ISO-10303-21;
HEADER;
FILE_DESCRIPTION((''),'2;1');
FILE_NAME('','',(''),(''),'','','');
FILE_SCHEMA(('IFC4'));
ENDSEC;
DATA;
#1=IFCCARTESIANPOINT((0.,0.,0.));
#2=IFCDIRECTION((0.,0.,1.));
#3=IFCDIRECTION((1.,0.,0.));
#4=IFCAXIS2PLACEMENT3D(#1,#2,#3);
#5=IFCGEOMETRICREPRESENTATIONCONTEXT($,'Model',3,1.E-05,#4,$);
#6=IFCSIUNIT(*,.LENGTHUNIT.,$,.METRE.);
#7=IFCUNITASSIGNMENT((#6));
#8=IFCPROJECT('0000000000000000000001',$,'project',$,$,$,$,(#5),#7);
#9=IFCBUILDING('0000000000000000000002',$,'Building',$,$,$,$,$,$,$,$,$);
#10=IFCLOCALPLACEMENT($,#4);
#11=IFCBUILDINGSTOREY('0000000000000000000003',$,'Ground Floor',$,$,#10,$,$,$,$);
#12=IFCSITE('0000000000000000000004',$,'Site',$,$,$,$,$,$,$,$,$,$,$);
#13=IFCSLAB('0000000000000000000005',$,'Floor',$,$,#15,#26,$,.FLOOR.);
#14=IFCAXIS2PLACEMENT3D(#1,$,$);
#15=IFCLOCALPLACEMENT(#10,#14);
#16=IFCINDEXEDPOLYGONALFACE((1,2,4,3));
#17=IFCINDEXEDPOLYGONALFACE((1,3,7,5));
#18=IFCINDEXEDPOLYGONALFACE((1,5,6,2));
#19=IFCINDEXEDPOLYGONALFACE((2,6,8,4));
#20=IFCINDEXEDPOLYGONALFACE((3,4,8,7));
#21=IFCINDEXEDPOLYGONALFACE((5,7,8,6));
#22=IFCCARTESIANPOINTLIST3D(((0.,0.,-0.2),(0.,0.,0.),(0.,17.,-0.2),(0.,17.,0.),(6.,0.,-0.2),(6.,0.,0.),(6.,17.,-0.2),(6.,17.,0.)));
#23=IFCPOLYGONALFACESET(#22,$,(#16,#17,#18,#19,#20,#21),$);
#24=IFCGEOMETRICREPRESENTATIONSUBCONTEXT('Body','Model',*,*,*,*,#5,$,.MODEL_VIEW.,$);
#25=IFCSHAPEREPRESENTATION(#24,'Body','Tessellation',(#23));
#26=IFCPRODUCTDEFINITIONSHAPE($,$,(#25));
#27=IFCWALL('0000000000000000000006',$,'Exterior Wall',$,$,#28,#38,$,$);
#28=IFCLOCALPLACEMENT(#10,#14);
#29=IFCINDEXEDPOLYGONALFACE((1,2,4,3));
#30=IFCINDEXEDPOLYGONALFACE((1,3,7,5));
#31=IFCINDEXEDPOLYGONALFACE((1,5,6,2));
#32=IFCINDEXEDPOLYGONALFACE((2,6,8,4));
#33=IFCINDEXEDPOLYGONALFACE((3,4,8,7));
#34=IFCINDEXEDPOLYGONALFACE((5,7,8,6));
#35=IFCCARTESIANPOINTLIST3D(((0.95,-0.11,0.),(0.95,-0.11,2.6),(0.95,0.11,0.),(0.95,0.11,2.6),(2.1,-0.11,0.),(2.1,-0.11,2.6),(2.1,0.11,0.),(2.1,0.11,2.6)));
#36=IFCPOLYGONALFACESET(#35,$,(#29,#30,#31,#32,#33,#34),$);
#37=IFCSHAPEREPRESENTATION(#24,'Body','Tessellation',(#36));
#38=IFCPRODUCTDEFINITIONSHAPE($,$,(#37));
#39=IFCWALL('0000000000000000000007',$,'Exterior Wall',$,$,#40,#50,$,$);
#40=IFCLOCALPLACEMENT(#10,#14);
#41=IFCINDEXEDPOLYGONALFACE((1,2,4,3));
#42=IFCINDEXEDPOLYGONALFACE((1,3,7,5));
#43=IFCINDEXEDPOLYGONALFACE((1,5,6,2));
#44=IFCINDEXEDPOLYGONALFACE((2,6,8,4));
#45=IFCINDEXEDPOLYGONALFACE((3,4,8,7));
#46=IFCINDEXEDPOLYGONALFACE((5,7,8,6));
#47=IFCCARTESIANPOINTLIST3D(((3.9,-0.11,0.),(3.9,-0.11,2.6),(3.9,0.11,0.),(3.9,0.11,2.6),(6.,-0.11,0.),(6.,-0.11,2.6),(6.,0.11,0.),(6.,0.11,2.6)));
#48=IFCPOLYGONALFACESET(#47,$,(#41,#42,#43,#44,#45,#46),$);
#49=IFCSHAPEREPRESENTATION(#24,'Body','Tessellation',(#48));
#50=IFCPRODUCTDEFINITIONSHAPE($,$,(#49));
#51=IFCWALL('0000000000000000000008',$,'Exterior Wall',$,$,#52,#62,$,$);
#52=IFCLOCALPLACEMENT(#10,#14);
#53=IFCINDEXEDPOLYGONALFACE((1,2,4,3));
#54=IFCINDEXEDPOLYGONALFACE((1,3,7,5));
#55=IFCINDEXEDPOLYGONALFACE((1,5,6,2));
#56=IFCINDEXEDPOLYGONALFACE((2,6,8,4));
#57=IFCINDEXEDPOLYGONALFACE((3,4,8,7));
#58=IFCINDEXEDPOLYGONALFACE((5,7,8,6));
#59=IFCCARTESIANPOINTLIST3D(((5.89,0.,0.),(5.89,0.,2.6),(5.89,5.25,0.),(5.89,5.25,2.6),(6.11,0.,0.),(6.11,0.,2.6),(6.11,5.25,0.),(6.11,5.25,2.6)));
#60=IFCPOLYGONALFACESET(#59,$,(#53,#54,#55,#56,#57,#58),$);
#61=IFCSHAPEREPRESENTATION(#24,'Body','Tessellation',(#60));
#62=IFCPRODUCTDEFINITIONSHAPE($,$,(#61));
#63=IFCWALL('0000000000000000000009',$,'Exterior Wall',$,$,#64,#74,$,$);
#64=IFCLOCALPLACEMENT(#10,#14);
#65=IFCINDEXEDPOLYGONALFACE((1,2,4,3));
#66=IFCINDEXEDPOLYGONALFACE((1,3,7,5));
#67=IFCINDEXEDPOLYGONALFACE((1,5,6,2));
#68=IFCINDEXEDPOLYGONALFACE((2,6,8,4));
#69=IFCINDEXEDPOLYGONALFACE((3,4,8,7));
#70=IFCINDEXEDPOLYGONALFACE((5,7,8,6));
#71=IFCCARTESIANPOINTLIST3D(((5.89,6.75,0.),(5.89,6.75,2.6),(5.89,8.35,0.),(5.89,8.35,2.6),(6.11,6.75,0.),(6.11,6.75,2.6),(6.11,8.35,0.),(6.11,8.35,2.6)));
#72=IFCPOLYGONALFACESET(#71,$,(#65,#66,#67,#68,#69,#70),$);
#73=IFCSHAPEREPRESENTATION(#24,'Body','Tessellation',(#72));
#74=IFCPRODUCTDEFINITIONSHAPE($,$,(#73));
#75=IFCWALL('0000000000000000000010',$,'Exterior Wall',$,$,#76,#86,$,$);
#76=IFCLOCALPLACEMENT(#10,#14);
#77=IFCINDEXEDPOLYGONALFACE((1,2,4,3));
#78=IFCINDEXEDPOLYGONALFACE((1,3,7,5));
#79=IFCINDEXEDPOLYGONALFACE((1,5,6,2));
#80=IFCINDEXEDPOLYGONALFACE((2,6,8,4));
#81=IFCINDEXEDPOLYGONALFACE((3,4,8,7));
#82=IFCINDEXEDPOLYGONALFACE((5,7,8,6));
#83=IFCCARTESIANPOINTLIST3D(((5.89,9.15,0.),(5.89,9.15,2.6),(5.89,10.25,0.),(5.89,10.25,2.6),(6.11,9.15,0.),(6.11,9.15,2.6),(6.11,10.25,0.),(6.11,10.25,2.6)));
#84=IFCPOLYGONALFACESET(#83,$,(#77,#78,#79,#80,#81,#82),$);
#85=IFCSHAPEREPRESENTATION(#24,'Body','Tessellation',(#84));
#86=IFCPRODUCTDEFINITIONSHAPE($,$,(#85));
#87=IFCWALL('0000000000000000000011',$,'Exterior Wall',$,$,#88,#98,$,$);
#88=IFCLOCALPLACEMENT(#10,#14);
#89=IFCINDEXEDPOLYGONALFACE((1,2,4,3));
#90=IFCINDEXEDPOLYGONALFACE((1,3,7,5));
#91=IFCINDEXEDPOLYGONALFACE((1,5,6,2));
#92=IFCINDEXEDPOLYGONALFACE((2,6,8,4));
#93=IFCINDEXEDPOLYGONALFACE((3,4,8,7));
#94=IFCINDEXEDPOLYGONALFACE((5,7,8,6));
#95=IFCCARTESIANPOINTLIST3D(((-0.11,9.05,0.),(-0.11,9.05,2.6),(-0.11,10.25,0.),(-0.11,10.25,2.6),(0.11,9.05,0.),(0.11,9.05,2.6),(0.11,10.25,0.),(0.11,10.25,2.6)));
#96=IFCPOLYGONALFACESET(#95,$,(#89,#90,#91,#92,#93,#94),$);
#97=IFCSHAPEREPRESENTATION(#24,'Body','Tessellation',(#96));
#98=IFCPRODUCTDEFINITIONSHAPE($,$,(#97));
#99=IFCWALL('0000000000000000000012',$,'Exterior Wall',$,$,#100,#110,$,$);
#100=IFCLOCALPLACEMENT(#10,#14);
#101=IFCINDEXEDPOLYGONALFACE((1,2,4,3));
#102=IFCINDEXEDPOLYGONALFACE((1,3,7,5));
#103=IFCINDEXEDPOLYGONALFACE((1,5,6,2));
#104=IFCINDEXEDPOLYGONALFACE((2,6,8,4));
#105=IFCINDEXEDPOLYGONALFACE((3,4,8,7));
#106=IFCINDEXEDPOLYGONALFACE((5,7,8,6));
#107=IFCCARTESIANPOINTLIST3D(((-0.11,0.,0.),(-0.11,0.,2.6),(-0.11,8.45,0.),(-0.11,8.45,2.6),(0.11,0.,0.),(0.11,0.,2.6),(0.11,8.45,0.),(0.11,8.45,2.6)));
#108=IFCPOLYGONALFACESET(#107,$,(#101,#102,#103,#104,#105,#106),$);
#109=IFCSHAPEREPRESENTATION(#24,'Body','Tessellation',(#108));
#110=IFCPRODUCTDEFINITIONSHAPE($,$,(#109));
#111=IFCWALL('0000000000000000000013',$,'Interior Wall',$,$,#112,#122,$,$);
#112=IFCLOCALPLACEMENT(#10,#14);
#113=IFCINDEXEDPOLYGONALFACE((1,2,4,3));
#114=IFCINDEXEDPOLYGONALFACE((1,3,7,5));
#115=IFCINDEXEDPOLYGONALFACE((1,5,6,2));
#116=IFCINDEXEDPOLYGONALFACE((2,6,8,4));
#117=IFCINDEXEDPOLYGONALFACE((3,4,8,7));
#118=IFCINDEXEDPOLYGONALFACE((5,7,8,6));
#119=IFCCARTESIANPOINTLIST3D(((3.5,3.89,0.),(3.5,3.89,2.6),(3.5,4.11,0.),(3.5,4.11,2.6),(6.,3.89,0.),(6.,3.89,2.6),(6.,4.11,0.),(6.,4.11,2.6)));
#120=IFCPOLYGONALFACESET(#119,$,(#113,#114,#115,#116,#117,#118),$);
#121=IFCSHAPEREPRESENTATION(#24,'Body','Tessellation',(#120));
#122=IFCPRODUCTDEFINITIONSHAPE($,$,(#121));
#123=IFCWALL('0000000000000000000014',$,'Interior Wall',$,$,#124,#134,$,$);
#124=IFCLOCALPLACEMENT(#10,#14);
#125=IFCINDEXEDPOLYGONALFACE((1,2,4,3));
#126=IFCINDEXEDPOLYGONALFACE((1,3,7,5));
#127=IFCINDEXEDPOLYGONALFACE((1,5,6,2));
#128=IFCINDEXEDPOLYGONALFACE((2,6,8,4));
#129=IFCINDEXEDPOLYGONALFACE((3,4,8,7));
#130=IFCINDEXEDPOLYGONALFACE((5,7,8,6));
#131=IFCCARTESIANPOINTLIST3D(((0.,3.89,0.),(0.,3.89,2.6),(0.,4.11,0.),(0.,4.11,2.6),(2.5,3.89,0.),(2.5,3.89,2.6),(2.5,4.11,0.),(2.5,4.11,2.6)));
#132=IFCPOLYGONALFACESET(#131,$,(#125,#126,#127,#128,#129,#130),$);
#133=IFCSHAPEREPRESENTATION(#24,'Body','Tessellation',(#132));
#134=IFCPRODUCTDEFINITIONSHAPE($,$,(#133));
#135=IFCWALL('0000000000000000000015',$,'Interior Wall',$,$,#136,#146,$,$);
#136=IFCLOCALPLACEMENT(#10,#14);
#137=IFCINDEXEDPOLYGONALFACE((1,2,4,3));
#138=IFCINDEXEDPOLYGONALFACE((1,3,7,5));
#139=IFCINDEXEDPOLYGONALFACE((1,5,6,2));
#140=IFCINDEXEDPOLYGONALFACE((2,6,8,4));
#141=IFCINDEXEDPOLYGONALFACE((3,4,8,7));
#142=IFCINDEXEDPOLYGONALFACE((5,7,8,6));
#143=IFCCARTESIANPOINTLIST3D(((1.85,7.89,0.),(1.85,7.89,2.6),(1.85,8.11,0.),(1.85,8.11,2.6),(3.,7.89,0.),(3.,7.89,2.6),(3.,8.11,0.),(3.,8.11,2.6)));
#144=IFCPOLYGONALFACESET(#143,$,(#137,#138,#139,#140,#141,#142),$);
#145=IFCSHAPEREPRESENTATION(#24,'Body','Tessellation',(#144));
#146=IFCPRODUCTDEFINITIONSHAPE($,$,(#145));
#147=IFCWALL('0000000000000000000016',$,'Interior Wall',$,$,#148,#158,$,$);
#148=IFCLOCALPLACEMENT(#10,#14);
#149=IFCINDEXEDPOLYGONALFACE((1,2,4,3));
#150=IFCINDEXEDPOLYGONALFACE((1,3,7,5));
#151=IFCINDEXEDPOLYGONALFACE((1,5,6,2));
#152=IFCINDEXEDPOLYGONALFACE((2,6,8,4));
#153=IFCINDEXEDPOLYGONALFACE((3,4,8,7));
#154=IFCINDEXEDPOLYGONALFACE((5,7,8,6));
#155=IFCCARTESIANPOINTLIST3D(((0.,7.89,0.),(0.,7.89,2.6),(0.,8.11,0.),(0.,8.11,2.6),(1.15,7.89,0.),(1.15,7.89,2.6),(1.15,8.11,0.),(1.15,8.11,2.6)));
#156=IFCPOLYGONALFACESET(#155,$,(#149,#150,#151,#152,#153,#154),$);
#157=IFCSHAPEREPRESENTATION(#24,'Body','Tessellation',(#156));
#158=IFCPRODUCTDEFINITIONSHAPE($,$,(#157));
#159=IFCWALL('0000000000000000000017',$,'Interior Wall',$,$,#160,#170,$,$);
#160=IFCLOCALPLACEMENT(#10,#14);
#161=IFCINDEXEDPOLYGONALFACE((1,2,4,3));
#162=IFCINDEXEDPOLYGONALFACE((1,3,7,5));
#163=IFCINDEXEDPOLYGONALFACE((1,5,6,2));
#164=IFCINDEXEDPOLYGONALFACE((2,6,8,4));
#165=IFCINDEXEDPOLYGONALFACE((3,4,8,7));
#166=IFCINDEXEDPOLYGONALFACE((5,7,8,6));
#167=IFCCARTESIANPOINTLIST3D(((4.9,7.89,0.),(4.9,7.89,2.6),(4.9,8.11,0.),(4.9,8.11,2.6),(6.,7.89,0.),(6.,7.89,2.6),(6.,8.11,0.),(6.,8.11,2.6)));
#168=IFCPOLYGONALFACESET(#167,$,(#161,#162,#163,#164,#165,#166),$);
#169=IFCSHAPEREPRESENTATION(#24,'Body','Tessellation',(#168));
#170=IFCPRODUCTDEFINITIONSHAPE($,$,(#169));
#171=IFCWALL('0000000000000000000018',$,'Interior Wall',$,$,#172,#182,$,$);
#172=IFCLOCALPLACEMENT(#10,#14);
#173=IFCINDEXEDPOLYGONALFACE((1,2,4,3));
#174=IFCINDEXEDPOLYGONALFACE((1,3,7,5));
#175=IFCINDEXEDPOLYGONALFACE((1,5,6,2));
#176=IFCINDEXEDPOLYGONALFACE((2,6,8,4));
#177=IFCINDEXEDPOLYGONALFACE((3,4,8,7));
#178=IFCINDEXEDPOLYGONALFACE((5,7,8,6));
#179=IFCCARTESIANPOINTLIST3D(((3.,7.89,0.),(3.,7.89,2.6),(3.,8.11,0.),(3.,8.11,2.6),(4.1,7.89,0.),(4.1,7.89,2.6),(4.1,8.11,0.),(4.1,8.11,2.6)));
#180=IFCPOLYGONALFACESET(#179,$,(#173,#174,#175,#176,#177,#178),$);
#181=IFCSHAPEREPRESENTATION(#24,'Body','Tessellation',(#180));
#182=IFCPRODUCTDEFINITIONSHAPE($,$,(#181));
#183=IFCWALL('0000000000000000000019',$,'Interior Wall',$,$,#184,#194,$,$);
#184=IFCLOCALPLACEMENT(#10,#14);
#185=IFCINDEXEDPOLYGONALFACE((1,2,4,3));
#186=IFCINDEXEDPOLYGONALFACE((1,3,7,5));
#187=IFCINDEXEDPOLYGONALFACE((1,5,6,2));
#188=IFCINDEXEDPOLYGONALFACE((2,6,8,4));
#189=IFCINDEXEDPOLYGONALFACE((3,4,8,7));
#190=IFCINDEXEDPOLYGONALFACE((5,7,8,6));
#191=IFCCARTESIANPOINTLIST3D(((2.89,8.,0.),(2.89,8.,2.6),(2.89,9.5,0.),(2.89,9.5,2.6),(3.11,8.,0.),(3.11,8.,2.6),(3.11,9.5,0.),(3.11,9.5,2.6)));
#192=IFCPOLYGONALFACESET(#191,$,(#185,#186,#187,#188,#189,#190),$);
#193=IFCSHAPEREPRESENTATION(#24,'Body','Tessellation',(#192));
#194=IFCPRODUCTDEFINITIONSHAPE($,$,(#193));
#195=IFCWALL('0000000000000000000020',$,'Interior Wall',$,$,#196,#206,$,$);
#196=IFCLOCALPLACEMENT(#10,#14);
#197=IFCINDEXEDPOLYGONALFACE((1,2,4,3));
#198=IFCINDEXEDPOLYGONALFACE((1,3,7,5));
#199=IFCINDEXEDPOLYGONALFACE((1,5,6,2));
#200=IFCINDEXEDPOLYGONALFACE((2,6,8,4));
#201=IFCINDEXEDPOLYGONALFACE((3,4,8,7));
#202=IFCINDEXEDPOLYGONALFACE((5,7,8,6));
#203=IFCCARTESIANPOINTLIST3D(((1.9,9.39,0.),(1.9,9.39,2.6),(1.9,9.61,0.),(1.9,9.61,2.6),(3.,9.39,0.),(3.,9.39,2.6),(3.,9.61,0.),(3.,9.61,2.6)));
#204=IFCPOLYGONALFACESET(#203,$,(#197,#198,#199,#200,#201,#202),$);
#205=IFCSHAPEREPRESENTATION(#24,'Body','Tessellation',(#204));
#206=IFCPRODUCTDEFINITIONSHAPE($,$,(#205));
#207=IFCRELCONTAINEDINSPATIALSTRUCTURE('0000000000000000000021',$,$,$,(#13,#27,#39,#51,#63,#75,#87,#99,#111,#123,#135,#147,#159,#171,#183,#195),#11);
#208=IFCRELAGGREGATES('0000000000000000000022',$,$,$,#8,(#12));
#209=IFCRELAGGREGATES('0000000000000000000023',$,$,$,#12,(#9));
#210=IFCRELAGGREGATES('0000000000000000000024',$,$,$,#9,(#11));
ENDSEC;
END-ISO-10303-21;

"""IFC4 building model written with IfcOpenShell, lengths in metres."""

from ifc_helpers import new_model, si_unit, frame, origin_with_axes, place, context, subcontext, project, spatial, indexed_curve, outline, extrude, element, save


model = new_model("IFC4")

# Units and contexts
model_context = context("Model", 3, precision=1e-05, world=origin_with_axes())
body_context = subcontext(model_context, "Body", "Model", "MODEL_VIEW")
ifc_project = project(units=[si_unit("LENGTHUNIT", "METRE")], contexts=[model_context])

# Site, building, storey
site = spatial("IfcSite", under=ifc_project, Name="Site")
building = spatial("IfcBuilding", under=site, Name="Building")
storey_placement = place(None, origin_with_axes())
storey = spatial("IfcBuildingStorey", under=building, at=storey_placement, Name="Ground Floor")

# Slab
slab_placement = place(storey_placement, frame((0.0, 0.0, -0.2), z_axis=(0.0, 0.0, 1.0), x_axis=(1.0, 0.0, 0.0)))
element("IfcSlab", 1, at=slab_placement, inside=storey, Name="Floor", PredefinedType="FLOOR", context=body_context, shape_type="SweptSolid", body=[
    extrude(outline(indexed_curve([(0.0, 0.0), (6.0, 0.0), (6.0, 17.0), (0.0, 17.0)])), None, (0.0, 0.0, 1.0), 0.2),
])

# Walls
wall_1_placement = place(storey_placement, frame((0.95, 0.0, 0.0), z_axis=(0.0, 0.0, 1.0), x_axis=(1.0, 0.0, 0.0)))
element("IfcWall", 2, at=wall_1_placement, inside=storey, Name="Exterior Wall", context=body_context, shape_type="SweptSolid", body=[
    extrude(outline(indexed_curve([(0.0, 0.0), (0.0, 0.22), (1.15, 0.22), (1.15, 0.0), (0.0, 0.0)], self_intersect=False)), frame((0.0, -0.11, 0.0), z_axis=(0.0, 0.0, 1.0), x_axis=(1.0, 0.0, 0.0)), (0.0, 0.0, 1.0), 2.6),
])
wall_2_placement = place(storey_placement, frame((3.9, 0.0, 0.0), z_axis=(0.0, 0.0, 1.0), x_axis=(1.0, 0.0, 0.0)))
element("IfcWall", 3, at=wall_2_placement, inside=storey, Name="Exterior Wall", context=body_context, shape_type="SweptSolid", body=[
    extrude(outline(indexed_curve([(0.0, 0.0), (0.0, 0.22), (2.1, 0.22), (2.1, 0.0), (0.0, 0.0)], self_intersect=False)), frame((0.0, -0.11, 0.0), z_axis=(0.0, 0.0, 1.0), x_axis=(1.0, 0.0, 0.0)), (0.0, 0.0, 1.0), 2.6),
])
wall_3_placement = place(storey_placement, frame((6.0, 0.0, 0.0), z_axis=(0.0, 0.0, 1.0), x_axis=(0.0, 1.0, 0.0)))
element("IfcWall", 4, at=wall_3_placement, inside=storey, Name="Exterior Wall", context=body_context, shape_type="SweptSolid", body=[
    extrude(outline(indexed_curve([(0.0, 0.0), (0.0, 0.22), (5.25, 0.22), (5.25, 0.0), (0.0, 0.0)], self_intersect=False)), frame((0.0, -0.11, 0.0), z_axis=(0.0, 0.0, 1.0), x_axis=(1.0, 0.0, 0.0)), (0.0, 0.0, 1.0), 2.6),
])
wall_4_placement = place(storey_placement, frame((6.0, 6.75, 0.0), z_axis=(0.0, 0.0, 1.0), x_axis=(0.0, 1.0, 0.0)))
element("IfcWall", 5, at=wall_4_placement, inside=storey, Name="Exterior Wall", context=body_context, shape_type="SweptSolid", body=[
    extrude(outline(indexed_curve([(0.0, 0.0), (0.0, 0.22), (1.6, 0.22), (1.6, 0.0), (0.0, 0.0)], self_intersect=False)), frame((0.0, -0.11, 0.0), z_axis=(0.0, 0.0, 1.0), x_axis=(1.0, 0.0, 0.0)), (0.0, 0.0, 1.0), 2.6),
])
wall_5_placement = place(storey_placement, frame((6.0, 9.15, 0.0), z_axis=(0.0, 0.0, 1.0), x_axis=(0.0, 1.0, 0.0)))
element("IfcWall", 6, at=wall_5_placement, inside=storey, Name="Exterior Wall", context=body_context, shape_type="SweptSolid", body=[
    extrude(outline(indexed_curve([(0.0, 0.0), (0.0, 0.22), (1.1, 0.22), (1.1, 0.0), (0.0, 0.0)], self_intersect=False)), frame((0.0, -0.11, 0.0), z_axis=(0.0, 0.0, 1.0), x_axis=(1.0, 0.0, 0.0)), (0.0, 0.0, 1.0), 2.6),
])
wall_6_placement = place(storey_placement, frame((0.0, 10.25, 0.0), z_axis=(0.0, 0.0, 1.0), x_axis=(0.0, -1.0, 0.0)))
element("IfcWall", 7, at=wall_6_placement, inside=storey, Name="Exterior Wall", context=body_context, shape_type="SweptSolid", body=[
    extrude(outline(indexed_curve([(0.0, 0.0), (0.0, 0.22), (1.2, 0.22), (1.2, 0.0), (0.0, 0.0)], self_intersect=False)), frame((0.0, -0.11, 0.0), z_axis=(0.0, 0.0, 1.0), x_axis=(1.0, 0.0, 0.0)), (0.0, 0.0, 1.0), 2.6),
])
wall_7_placement = place(storey_placement, frame((0.0, 8.45, 0.0), z_axis=(0.0, 0.0, 1.0), x_axis=(0.0, -1.0, 0.0)))
element("IfcWall", 8, at=wall_7_placement, inside=storey, Name="Exterior Wall", context=body_context, shape_type="SweptSolid", body=[
    extrude(outline(indexed_curve([(0.0, 0.0), (0.0, 0.22), (8.45, 0.22), (8.45, 0.0), (0.0, 0.0)], self_intersect=False)), frame((0.0, -0.11, 0.0), z_axis=(0.0, 0.0, 1.0), x_axis=(1.0, 0.0, 0.0)), (0.0, 0.0, 1.0), 2.6),
])
for number, where, z_axis, x_axis, name in (
    (9, (6.0, 4.0, 0.0), (0.0, 0.0, 1.0), (-1.0, 0.0, 0.0), "Interior Wall"),
    (10, (2.5, 4.0, 0.0), (0.0, 0.0, 1.0), (-1.0, 0.0, 0.0), "Interior Wall"),
):
    element("IfcWall", number, at=place(storey_placement, frame(where, z_axis=z_axis, x_axis=x_axis)), inside=storey, Name=name, context=body_context, shape_type="SweptSolid", body=[
        extrude(outline(indexed_curve([(0.0, 0.0), (0.0, 0.22), (2.5, 0.22), (2.5, 0.0), (0.0, 0.0)], self_intersect=False)), frame((0.0, -0.11, 0.0), z_axis=(0.0, 0.0, 1.0), x_axis=(1.0, 0.0, 0.0)), (0.0, 0.0, 1.0), 2.6),
    ])
for number, where, z_axis, x_axis, name in (
    (11, (3.0, 8.0, 0.0), (0.0, 0.0, 1.0), (-1.0, 0.0, 0.0), "Interior Wall"),
    (12, (1.15, 8.0, 0.0), (0.0, 0.0, 1.0), (-1.0, 0.0, 0.0), "Interior Wall"),
):
    element("IfcWall", number, at=place(storey_placement, frame(where, z_axis=z_axis, x_axis=x_axis)), inside=storey, Name=name, context=body_context, shape_type="SweptSolid", body=[
        extrude(outline(indexed_curve([(0.0, 0.0), (0.0, 0.22), (1.15, 0.22), (1.15, 0.0), (0.0, 0.0)], self_intersect=False)), frame((0.0, -0.11, 0.0), z_axis=(0.0, 0.0, 1.0), x_axis=(1.0, 0.0, 0.0)), (0.0, 0.0, 1.0), 2.6),
    ])
for number, where, z_axis, x_axis, name in (
    (13, (6.0, 8.0, 0.0), (0.0, 0.0, 1.0), (-1.0, 0.0, 0.0), "Interior Wall"),
    (14, (4.1, 8.0, 0.0), (0.0, 0.0, 1.0), (-1.0, 0.0, 0.0), "Interior Wall"),
):
    element("IfcWall", number, at=place(storey_placement, frame(where, z_axis=z_axis, x_axis=x_axis)), inside=storey, Name=name, context=body_context, shape_type="SweptSolid", body=[
        extrude(outline(indexed_curve([(0.0, 0.0), (0.0, 0.22), (1.1, 0.22), (1.1, 0.0), (0.0, 0.0)], self_intersect=False)), frame((0.0, -0.11, 0.0), z_axis=(0.0, 0.0, 1.0), x_axis=(1.0, 0.0, 0.0)), (0.0, 0.0, 1.0), 2.6),
    ])
wall_8_placement = place(storey_placement, frame((3.0, 8.0, 0.0), z_axis=(0.0, 0.0, 1.0), x_axis=(0.0, 1.0, 0.0)))
element("IfcWall", 15, at=wall_8_placement, inside=storey, Name="Interior Wall", context=body_context, shape_type="SweptSolid", body=[
    extrude(outline(indexed_curve([(0.0, 0.0), (0.0, 0.22), (1.5, 0.22), (1.5, 0.0), (0.0, 0.0)], self_intersect=False)), frame((0.0, -0.11, 0.0), z_axis=(0.0, 0.0, 1.0), x_axis=(1.0, 0.0, 0.0)), (0.0, 0.0, 1.0), 2.6),
])
for number, where, z_axis, x_axis, name in (
    (16, (3.0, 9.5, 0.0), (0.0, 0.0, 1.0), (-1.0, 0.0, 0.0), "Interior Wall"),
):
    element("IfcWall", number, at=place(storey_placement, frame(where, z_axis=z_axis, x_axis=x_axis)), inside=storey, Name=name, context=body_context, shape_type="SweptSolid", body=[
        extrude(outline(indexed_curve([(0.0, 0.0), (0.0, 0.22), (1.1, 0.22), (1.1, 0.0), (0.0, 0.0)], self_intersect=False)), frame((0.0, -0.11, 0.0), z_axis=(0.0, 0.0, 1.0), x_axis=(1.0, 0.0, 0.0)), (0.0, 0.0, 1.0), 2.6),
    ])

save(model, "model.ifc")
